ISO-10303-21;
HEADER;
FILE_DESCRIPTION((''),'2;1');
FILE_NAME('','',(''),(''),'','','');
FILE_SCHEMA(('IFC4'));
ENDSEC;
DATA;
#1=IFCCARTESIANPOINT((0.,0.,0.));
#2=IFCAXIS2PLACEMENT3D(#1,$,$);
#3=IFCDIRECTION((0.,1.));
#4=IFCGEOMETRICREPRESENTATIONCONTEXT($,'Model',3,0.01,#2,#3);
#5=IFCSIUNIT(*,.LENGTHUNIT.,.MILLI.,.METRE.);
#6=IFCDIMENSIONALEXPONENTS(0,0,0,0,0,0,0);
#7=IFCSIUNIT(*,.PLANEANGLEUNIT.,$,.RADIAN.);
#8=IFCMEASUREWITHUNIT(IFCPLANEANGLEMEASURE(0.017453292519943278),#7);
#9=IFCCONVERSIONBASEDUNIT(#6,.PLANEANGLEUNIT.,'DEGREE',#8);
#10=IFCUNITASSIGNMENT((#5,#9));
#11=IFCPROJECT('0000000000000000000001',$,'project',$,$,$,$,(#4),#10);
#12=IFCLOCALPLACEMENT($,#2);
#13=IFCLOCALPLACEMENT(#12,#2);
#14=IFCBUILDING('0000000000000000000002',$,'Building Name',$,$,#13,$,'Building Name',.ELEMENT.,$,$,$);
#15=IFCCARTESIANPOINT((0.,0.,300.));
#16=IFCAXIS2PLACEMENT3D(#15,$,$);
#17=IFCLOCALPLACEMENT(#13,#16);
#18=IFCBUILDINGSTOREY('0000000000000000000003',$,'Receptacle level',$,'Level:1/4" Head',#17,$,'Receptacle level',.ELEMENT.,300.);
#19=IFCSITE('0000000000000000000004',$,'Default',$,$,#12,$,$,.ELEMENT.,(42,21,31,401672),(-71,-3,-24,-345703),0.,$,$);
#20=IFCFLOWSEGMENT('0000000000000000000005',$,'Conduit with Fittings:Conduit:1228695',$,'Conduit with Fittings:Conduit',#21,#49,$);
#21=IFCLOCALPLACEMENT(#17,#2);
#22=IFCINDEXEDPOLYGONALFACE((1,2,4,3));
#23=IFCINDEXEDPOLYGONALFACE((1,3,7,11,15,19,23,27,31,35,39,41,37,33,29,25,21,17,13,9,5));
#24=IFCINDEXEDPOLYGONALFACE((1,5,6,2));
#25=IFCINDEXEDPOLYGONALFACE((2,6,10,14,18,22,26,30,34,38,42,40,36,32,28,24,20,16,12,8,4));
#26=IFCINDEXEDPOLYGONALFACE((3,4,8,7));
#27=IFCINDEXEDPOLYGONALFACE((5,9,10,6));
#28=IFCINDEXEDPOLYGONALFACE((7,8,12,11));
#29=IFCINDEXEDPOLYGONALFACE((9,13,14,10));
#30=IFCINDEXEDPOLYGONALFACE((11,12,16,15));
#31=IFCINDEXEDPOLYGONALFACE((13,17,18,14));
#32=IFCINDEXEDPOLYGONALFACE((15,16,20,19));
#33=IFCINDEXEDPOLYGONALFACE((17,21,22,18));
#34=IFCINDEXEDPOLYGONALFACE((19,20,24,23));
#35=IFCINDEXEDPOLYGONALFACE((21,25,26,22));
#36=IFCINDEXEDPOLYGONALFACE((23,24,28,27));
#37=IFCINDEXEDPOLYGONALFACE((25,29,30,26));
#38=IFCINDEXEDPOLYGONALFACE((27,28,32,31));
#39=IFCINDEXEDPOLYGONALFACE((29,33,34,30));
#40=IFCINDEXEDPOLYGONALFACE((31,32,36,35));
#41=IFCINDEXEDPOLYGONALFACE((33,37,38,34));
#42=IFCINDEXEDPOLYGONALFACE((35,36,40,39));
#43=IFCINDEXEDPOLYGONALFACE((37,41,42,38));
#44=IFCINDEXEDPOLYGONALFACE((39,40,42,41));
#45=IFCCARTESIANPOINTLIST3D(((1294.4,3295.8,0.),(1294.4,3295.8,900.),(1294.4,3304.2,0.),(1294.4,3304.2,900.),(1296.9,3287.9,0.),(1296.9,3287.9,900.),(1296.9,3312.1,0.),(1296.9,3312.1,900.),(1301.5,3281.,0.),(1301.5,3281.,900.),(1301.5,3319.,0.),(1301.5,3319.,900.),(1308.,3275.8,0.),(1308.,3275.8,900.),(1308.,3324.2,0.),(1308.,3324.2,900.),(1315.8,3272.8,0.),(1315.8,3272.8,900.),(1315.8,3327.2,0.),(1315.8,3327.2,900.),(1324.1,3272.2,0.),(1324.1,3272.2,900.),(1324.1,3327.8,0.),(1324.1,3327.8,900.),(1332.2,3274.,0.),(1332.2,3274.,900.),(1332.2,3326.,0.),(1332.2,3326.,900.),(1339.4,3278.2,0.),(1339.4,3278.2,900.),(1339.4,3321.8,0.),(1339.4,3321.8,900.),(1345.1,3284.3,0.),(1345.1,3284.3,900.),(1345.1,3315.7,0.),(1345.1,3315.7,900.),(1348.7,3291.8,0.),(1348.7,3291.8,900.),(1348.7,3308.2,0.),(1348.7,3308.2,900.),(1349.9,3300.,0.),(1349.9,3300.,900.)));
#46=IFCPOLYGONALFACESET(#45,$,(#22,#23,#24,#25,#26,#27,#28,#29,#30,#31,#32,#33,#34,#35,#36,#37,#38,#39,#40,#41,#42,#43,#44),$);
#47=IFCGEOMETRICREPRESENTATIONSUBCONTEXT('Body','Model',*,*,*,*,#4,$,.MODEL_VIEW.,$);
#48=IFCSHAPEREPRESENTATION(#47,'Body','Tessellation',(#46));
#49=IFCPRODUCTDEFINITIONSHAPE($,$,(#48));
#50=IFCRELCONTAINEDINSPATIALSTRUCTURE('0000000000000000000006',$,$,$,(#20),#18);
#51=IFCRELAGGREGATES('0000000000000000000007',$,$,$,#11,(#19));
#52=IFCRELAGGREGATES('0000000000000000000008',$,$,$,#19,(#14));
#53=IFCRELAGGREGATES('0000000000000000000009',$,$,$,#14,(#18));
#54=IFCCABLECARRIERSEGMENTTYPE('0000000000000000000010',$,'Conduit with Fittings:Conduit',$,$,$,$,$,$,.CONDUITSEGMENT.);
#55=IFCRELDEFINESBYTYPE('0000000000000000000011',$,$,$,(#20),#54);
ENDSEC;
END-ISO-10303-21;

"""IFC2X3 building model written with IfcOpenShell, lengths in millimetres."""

from ifc_helpers import new_model, entity, si_unit, converted_unit, direction, frame, frame_2d, origin, place, context, subcontext, project, spatial, circle, extrude, type_object, element, save


model = new_model("IFC2X3")

# Units and contexts
model_context = context("Model", 3, precision=0.01, world=origin(), true_north=direction((0.0, 1.0)))
body_context = subcontext(model_context, "Body", "Model", "MODEL_VIEW")
ifc_project = project(units=[si_unit("LENGTHUNIT", "METRE", prefix="MILLI"), converted_unit("PLANEANGLEUNIT", "DEGREE", entity("IfcPlaneAngleMeasure", 0.017453292519943278), si_unit("PLANEANGLEUNIT", "RADIAN"), dimensions=[0, 0, 0, 0, 0, 0, 0])], contexts=[model_context])

# Site, building, storey
site_placement = place(None, origin())
site = spatial("IfcSite", under=ifc_project, at=site_placement, Name="Default", CompositionType="ELEMENT", RefLatitude=(42, 21, 31, 401672), RefLongitude=(-71, -3, -24, -345703), RefElevation=0.0)
building_placement = place(site_placement, origin())
building = spatial("IfcBuilding", under=site, at=building_placement, Name="Building Name", LongName="Building Name", CompositionType="ELEMENT")
storey_placement = place(building_placement, frame((0.0, 0.0, 300.0)))
storey = spatial("IfcBuildingStorey", under=building, at=storey_placement, Name="Receptacle level", ObjectType="Level:1/4\" Head", LongName="Receptacle level", CompositionType="ELEMENT", Elevation=300.0)

# Flow segment
cable_carrier_segment_type = type_object("IfcCableCarrierSegmentType", Name="Conduit with Fittings:Conduit", PredefinedType="CONDUITSEGMENT")
flow_segment_placement = place(storey_placement, origin())
element("IfcFlowSegment", 1, at=flow_segment_placement, inside=storey, type_object=cable_carrier_segment_type, Name="Conduit with Fittings:Conduit:1228695", ObjectType="Conduit with Fittings:Conduit", context=body_context, shape_type="SweptSolid", body=[
    extrude(circle(Radius=27.9, at=frame_2d((0.0, 0.0), x_axis=(1.0, 0.0))), frame((1322.0, 3300.0, 0.0)), (0.0, 0.0, 1.0), 900.0),
])

save(model, "model.ifc")
